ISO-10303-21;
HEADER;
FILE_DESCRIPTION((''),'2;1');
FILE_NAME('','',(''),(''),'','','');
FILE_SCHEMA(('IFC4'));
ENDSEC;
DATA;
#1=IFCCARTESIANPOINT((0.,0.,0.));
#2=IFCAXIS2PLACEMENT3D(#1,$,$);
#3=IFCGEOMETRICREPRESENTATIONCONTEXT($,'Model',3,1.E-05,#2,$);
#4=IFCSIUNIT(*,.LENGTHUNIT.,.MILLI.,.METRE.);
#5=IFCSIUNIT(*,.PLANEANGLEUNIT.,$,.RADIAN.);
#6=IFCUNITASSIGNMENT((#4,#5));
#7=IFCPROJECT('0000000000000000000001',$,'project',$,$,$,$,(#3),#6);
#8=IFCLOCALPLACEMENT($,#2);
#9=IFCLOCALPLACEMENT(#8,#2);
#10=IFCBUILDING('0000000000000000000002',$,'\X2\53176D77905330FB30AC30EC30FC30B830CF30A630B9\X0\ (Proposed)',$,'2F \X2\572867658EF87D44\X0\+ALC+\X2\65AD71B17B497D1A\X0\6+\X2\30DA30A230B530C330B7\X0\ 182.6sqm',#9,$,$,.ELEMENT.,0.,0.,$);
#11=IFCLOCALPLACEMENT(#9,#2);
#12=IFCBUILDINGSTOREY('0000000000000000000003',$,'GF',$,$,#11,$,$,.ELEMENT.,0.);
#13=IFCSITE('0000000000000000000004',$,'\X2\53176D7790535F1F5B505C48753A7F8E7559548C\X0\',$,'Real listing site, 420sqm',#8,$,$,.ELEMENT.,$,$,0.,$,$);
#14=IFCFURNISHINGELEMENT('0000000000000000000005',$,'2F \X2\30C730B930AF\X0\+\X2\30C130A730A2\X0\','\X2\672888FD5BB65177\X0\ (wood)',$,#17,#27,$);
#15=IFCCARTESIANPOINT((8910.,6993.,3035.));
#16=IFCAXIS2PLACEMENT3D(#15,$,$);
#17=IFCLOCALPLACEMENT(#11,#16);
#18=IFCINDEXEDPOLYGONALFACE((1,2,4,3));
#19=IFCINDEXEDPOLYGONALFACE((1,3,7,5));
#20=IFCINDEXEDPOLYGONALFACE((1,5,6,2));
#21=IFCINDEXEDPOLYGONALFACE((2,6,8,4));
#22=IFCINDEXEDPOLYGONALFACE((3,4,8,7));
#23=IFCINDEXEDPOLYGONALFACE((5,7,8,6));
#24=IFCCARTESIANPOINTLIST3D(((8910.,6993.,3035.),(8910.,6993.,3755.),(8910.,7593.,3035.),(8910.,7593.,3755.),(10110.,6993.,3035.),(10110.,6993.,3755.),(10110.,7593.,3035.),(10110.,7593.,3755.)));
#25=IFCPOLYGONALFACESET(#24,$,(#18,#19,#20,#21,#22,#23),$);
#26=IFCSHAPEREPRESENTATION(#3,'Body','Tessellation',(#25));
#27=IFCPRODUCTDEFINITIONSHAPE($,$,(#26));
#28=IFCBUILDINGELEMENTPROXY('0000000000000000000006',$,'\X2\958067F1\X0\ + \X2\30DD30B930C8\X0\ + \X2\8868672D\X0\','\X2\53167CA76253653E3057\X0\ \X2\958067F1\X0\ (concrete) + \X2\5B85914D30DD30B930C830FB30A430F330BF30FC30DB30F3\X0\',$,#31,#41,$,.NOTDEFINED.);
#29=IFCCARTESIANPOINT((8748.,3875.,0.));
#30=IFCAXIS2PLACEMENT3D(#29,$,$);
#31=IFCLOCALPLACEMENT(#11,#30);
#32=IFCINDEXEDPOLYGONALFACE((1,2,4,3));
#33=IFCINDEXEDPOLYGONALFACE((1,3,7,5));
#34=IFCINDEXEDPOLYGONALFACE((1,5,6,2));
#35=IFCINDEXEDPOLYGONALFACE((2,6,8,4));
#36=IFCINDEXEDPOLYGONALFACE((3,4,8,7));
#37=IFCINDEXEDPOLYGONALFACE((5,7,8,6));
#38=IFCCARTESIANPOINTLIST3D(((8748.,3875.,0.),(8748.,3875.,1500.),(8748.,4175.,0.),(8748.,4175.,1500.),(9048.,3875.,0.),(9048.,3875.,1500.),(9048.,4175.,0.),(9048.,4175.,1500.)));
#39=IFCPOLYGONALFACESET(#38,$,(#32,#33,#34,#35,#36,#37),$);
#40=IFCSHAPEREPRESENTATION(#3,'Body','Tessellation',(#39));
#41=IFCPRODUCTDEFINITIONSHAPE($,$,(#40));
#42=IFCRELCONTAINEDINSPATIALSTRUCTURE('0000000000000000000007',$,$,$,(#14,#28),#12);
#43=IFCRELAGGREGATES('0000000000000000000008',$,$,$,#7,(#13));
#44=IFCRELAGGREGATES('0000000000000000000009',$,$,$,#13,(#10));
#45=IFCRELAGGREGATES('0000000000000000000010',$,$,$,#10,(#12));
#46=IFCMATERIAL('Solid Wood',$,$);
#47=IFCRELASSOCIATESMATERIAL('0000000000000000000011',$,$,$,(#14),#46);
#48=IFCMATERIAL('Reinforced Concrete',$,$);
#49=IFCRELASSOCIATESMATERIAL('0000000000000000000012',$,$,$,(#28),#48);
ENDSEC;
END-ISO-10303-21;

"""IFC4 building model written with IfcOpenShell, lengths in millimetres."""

from ifc_helpers import new_model, si_unit, frame, frame_2d, origin, place, context, project, spatial, rectangle, extrude, material, element, save


model = new_model("IFC4")

# Units and contexts
model_context = context("Model", 3, precision=1e-05, world=origin())
ifc_project = project(units=[si_unit("LENGTHUNIT", "METRE", prefix="MILLI"), si_unit("PLANEANGLEUNIT", "RADIAN")], contexts=[model_context])

# Site, building, storey
site_placement = place(None, origin())
site = spatial("IfcSite", under=ifc_project, at=site_placement, Name="北海道弟子屈町美留和", ObjectType="Real listing site, 420sqm", CompositionType="ELEMENT", RefElevation=0.0)
building_placement = place(site_placement, origin())
building = spatial("IfcBuilding", under=site, at=building_placement, Name="北海道・ガレージハウス (Proposed)", ObjectType="2F 在来軸組+ALC+断熱等級6+ペアサッシ 182.6sqm", CompositionType="ELEMENT", ElevationOfRefHeight=0.0, ElevationOfTerrain=0.0)
storey_placement = place(building_placement, origin())
storey = spatial("IfcBuildingStorey", under=building, at=storey_placement, Name="GF", CompositionType="ELEMENT", Elevation=0.0)

# Shared definitions
ifc_material_1 = material(Name="Solid Wood")

# Shared definitions
ifc_material_2 = material(Name="Reinforced Concrete")

# Furnishing element
furnishing_1_placement = place(storey_placement, frame((8910.0, 6993.0, 3035.0)))
element("IfcFurnishingElement", 1, at=furnishing_1_placement, inside=storey, material=ifc_material_1, Name="2F デスク+チェア", Description="木製家具 (wood)", context=model_context, shape_type="SweptSolid", body=[
    extrude(rectangle(XDim=1200.0, YDim=600.0, at=frame_2d((600.0, 300.0))), frame((8910.0, 6993.0, 3035.0)), (0.0, 0.0, 1.0), 720.0),
])

# Building element proxy
proxy_placement = place(storey_placement, frame((8748.0, 3875.0, 0.0)))
element("IfcBuildingElementProxy", 2, at=proxy_placement, inside=storey, material=ifc_material_2, Name="門柱 + ポスト + 表札", Description="化粧打放し 門柱 (concrete) + 宅配ポスト・インターホン", PredefinedType="NOTDEFINED", context=model_context, shape_type="SweptSolid", body=[
    extrude(rectangle(XDim=300.0, YDim=300.0, at=frame_2d((150.0, 150.0))), frame((8748.0, 3875.0, 0.0)), (0.0, 0.0, 1.0), 1500.0),
])

save(model, "model.ifc")
